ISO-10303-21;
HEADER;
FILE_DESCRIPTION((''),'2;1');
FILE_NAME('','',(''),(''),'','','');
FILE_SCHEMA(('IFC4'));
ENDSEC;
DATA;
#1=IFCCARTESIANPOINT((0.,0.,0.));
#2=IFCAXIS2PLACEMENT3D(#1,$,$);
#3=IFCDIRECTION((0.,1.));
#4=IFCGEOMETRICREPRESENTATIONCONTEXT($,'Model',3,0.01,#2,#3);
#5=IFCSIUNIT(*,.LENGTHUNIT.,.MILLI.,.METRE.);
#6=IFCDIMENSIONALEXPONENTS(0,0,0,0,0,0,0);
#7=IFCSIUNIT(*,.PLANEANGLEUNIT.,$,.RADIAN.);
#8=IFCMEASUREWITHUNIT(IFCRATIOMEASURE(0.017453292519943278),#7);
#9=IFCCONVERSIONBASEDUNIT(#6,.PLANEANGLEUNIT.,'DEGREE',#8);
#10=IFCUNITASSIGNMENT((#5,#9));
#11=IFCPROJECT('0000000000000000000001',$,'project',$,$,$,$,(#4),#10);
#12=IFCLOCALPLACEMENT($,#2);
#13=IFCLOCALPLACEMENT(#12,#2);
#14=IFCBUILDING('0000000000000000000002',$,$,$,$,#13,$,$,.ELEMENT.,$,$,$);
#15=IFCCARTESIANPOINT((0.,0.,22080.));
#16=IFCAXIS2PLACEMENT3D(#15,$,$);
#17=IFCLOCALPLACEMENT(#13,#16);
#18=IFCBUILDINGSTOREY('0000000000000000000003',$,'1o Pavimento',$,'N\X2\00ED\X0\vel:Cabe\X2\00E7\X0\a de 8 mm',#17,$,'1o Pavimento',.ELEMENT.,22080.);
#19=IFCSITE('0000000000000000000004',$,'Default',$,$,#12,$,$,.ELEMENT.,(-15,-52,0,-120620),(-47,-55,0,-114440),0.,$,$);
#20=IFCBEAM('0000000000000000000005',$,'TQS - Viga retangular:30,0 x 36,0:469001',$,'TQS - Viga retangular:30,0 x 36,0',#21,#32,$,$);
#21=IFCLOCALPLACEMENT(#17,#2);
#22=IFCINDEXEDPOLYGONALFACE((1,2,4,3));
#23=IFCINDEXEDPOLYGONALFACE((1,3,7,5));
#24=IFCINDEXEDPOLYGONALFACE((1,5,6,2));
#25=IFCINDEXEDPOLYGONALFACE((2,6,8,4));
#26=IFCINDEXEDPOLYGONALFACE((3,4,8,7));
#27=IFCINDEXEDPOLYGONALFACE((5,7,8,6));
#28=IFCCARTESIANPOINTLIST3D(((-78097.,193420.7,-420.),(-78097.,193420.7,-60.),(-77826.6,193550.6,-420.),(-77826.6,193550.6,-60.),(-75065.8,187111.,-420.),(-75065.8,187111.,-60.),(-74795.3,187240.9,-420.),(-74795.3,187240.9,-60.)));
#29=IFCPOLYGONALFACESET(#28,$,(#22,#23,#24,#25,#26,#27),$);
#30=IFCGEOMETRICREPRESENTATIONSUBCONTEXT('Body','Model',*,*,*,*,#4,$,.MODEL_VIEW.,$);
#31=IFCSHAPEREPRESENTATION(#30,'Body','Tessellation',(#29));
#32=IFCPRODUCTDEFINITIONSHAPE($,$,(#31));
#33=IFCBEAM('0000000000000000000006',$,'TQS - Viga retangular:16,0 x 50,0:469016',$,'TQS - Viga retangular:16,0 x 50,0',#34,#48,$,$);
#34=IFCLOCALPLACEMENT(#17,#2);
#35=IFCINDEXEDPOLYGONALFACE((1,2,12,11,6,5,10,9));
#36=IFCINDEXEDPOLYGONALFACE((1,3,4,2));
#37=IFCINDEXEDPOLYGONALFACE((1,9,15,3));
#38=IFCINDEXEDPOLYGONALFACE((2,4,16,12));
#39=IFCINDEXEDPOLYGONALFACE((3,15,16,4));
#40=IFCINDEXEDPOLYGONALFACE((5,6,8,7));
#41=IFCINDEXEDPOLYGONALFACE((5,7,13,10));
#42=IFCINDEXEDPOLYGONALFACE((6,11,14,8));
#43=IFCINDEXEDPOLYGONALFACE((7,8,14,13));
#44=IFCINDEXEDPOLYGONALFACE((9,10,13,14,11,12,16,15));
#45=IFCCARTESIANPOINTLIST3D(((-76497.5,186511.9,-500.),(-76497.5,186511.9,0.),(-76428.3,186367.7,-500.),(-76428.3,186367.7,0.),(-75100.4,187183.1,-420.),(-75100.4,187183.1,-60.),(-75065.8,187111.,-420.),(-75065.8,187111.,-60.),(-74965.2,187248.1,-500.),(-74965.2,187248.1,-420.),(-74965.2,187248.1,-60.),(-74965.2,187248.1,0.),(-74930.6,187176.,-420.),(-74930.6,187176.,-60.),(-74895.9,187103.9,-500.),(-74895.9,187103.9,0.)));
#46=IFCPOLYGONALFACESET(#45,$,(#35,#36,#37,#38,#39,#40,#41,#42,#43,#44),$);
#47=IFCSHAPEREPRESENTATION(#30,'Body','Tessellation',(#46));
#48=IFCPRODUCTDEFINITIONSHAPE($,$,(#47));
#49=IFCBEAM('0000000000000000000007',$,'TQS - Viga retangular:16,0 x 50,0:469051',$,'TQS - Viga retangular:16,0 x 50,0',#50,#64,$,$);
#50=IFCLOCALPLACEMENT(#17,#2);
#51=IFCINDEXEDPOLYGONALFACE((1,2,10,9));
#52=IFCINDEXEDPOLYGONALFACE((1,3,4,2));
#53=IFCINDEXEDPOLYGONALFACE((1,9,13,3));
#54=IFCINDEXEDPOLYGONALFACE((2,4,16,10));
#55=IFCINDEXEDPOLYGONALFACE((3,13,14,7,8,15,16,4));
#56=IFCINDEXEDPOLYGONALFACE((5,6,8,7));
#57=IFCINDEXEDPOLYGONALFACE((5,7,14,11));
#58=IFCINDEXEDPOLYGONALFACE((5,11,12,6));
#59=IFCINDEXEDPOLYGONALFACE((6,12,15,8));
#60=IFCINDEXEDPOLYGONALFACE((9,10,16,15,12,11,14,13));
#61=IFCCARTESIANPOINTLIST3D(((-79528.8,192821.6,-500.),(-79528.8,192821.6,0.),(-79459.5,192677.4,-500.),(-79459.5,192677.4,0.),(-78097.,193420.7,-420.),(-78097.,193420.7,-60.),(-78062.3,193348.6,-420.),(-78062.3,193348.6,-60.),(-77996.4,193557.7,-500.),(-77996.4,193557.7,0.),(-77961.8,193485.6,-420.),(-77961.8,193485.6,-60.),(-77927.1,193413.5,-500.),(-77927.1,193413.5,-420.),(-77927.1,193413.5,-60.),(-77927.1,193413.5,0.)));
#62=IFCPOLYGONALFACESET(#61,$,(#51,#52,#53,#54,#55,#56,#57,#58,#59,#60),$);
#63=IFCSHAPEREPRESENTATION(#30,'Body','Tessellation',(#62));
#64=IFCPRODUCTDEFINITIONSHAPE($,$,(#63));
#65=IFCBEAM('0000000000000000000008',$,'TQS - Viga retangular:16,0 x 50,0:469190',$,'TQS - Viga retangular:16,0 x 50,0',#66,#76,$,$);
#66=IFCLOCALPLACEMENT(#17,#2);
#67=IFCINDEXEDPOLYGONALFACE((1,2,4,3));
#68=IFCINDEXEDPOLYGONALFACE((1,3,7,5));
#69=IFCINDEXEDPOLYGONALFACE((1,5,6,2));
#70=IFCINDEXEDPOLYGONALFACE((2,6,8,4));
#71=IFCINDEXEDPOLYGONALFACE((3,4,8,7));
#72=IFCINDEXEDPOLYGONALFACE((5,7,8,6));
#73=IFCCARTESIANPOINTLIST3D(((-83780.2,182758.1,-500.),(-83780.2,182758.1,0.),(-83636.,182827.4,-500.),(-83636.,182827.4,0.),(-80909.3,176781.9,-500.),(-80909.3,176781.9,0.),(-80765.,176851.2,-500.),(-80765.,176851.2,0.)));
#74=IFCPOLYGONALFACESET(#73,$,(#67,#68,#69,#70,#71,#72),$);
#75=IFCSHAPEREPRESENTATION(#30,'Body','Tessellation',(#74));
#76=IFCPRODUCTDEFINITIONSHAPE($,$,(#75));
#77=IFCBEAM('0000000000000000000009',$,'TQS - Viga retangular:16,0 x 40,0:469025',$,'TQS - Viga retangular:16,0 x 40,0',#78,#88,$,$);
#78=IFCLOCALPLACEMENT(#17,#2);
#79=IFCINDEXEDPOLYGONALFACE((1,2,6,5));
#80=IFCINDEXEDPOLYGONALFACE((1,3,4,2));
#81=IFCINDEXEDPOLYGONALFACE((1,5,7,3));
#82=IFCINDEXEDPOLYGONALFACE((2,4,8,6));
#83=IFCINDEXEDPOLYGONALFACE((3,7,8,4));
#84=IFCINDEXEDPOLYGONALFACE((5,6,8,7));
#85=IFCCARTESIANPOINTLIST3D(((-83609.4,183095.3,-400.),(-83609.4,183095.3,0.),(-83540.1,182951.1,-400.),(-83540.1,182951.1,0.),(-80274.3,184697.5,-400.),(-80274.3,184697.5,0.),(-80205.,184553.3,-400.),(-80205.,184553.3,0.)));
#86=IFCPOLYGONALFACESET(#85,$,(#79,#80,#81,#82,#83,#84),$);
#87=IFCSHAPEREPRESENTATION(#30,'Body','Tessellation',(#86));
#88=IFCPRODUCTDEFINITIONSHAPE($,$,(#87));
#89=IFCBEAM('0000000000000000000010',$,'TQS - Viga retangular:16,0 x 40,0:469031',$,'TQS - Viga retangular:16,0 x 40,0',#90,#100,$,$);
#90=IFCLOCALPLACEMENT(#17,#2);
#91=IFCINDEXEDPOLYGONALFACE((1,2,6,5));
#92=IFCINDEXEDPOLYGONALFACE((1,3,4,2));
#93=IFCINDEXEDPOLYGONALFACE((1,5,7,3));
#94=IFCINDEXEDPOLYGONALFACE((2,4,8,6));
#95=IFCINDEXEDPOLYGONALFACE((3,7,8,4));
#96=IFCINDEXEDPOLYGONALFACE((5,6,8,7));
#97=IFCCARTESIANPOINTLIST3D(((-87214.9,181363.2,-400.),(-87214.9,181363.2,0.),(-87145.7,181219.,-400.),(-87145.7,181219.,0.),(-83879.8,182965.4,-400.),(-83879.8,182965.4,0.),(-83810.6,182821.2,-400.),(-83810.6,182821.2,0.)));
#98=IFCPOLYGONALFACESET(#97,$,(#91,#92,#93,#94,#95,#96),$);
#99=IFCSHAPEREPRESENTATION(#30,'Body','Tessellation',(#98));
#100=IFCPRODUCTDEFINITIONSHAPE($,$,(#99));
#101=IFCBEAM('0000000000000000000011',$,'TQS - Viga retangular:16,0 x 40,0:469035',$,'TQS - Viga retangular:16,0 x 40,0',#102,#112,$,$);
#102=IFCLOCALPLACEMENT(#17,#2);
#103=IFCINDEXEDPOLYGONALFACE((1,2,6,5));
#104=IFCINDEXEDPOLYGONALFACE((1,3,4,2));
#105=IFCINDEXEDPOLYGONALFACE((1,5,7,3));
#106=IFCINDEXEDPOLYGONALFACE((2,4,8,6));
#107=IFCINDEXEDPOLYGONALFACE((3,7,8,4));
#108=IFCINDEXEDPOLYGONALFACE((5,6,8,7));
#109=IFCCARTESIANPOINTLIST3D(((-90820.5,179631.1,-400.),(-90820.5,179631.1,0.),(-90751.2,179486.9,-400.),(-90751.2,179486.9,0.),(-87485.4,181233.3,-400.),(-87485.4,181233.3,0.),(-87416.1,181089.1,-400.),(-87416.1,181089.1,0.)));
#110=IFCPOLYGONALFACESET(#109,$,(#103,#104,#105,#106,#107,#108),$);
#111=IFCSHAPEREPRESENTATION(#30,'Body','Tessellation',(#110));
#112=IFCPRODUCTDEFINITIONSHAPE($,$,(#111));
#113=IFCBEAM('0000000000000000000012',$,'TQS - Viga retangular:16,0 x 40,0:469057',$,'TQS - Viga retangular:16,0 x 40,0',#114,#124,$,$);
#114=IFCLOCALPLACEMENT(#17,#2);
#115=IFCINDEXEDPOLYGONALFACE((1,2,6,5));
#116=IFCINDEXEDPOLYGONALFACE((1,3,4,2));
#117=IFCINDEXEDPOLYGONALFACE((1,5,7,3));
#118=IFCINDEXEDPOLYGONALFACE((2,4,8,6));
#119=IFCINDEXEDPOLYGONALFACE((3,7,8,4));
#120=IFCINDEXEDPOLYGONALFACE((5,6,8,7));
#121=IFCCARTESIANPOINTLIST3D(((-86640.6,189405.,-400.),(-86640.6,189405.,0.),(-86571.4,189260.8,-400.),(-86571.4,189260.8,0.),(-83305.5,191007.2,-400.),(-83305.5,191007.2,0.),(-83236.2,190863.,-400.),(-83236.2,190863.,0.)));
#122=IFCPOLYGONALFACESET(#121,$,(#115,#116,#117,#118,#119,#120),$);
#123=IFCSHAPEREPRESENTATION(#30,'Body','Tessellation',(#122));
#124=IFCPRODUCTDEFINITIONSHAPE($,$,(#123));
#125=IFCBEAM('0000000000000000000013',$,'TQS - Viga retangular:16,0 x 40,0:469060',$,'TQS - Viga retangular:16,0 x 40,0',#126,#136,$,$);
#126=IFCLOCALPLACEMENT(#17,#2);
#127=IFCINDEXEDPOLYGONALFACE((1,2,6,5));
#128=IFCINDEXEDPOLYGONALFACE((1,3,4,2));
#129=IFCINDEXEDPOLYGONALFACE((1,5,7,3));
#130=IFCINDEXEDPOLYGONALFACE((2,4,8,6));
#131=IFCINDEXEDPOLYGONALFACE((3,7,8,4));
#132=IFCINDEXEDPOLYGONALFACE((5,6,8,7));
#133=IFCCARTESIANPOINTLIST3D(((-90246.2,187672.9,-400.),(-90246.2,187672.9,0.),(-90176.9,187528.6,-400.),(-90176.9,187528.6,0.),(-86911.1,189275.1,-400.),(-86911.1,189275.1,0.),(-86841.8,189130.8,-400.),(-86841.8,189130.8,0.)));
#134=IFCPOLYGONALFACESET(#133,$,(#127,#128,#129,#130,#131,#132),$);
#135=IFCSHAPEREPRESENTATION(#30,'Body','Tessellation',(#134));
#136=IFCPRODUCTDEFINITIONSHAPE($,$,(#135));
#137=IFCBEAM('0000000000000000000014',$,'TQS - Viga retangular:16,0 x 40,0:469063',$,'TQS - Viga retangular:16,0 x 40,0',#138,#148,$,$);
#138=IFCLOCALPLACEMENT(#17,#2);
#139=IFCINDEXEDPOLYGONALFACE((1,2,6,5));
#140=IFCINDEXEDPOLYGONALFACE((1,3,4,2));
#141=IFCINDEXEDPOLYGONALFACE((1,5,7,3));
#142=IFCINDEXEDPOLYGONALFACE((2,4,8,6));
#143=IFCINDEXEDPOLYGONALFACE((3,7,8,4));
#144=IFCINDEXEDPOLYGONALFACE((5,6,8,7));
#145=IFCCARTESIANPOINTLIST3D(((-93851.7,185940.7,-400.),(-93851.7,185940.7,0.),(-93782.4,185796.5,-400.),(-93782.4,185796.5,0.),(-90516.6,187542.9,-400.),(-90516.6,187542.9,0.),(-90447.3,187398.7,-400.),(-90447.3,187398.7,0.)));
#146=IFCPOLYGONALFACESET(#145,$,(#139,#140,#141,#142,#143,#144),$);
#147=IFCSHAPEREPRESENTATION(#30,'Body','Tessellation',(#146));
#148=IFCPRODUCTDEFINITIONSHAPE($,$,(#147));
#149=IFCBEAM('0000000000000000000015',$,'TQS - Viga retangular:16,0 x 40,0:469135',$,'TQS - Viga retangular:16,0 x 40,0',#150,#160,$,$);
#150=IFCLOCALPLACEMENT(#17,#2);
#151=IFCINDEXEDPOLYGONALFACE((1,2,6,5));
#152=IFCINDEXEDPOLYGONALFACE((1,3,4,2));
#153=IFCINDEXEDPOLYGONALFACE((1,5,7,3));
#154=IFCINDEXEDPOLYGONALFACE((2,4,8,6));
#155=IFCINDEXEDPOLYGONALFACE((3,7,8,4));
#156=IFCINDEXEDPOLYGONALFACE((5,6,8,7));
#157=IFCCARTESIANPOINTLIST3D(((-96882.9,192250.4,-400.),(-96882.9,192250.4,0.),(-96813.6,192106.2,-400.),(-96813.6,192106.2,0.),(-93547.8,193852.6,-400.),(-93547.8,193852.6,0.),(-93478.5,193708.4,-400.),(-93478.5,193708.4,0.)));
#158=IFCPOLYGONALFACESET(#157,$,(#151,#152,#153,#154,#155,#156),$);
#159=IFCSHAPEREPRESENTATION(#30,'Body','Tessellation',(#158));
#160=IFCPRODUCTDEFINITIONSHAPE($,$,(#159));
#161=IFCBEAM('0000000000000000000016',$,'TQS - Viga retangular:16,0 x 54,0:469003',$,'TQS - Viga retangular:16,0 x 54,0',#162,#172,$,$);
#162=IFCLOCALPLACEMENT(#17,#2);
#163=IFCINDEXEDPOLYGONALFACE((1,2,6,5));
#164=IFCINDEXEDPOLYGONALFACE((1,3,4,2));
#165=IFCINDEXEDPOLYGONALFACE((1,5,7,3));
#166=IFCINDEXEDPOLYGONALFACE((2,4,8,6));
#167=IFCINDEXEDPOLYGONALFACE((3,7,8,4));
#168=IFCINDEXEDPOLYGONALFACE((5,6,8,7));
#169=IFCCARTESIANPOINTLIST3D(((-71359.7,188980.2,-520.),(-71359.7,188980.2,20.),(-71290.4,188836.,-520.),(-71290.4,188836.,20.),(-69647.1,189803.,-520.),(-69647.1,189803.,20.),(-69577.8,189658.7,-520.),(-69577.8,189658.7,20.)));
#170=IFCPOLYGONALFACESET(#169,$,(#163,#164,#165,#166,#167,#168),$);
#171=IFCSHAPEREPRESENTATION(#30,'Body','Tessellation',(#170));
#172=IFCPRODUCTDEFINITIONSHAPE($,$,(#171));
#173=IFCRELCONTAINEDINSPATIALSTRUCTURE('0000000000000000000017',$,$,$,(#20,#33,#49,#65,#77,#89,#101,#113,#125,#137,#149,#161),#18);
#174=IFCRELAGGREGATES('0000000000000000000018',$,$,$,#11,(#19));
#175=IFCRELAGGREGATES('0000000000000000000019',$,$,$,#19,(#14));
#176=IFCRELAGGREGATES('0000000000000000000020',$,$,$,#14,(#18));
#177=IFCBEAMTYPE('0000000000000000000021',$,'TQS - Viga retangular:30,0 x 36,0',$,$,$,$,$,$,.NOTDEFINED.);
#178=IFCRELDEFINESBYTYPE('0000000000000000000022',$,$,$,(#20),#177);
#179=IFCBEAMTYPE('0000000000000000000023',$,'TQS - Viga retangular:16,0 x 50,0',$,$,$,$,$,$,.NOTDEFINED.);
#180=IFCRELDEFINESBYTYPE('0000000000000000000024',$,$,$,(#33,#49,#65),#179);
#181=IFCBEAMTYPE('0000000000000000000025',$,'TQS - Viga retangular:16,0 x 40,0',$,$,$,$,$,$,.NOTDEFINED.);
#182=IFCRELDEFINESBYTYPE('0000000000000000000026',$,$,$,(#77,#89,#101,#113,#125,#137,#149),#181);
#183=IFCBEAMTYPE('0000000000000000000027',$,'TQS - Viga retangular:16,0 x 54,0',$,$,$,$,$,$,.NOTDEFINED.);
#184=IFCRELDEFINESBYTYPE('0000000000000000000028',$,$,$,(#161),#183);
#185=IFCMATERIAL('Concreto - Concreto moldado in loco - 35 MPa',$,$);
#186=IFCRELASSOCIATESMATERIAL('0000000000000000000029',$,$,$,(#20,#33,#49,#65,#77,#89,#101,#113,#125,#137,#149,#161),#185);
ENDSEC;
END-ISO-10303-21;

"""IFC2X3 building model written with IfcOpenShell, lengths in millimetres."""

from ifc_helpers import new_model, entity, si_unit, converted_unit, direction, frame, frame_2d, origin, origin_2d_with_axis, place, context, subcontext, project, spatial, polyline, rectangle, extrude, boolean, clip, bounded_halfspace, material, type_object, element, save


model = new_model("IFC2X3")

# Units and contexts
model_context = context("Model", 3, precision=0.01, world=origin(), true_north=direction((0.0, 1.0)))
body_context = subcontext(model_context, "Body", "Model", "MODEL_VIEW")
ifc_project = project(units=[si_unit("LENGTHUNIT", "METRE", prefix="MILLI"), converted_unit("PLANEANGLEUNIT", "DEGREE", entity("IfcRatioMeasure", 0.017453292519943278), si_unit("PLANEANGLEUNIT", "RADIAN"), dimensions=[0, 0, 0, 0, 0, 0, 0])], contexts=[model_context])

# Site, building, storey
site_placement = place(None, origin())
site = spatial("IfcSite", under=ifc_project, at=site_placement, Name="Default", CompositionType="ELEMENT", RefLatitude=(-15, -52, 0, -120620), RefLongitude=(-47, -55, 0, -114440), RefElevation=0.0)
building_placement = place(site_placement, origin())
building = spatial("IfcBuilding", under=site, at=building_placement, CompositionType="ELEMENT")
storey_placement = place(building_placement, frame((0.0, 0.0, 22080.0)))
storey = spatial("IfcBuildingStorey", under=building, at=storey_placement, Name="1o Pavimento", ObjectType="Nível:Cabeça de 8 mm", LongName="1o Pavimento", CompositionType="ELEMENT", Elevation=22080.0)

# Beams
ifc_material_1 = material(Name="Concreto - Concreto moldado in loco - 35 MPa")
beam_type_1 = type_object("IfcBeamType", Name="TQS - Viga retangular:30,0 x 36,0", PredefinedType="NOTDEFINED")
beam_1_placement = place(storey_placement, frame((-74930.6, 187176.0, -60.0), z_axis=(0.0, 0.0, 1.0), x_axis=(-0.43303, 0.90138, 0.0)))
element("IfcBeam", 1, at=beam_1_placement, inside=storey, type_object=beam_type_1, material=ifc_material_1, Name="TQS - Viga retangular:30,0 x 36,0:469001", ObjectType="TQS - Viga retangular:30,0 x 36,0", context=body_context, shape_type="SweptSolid", body=[
    extrude(rectangle(XDim=360.0, YDim=300.0, at=frame_2d((0.0, 0.0), x_axis=(1.0, 0.0))), frame((0.0, 0.0, -180.0), z_axis=(1.0, 0.0, 0.0), x_axis=(0.0, 0.0, -1.0)), (0.0, 0.0, 1.0), 7000.0),
])
beam_type_2 = type_object("IfcBeamType", Name="TQS - Viga retangular:16,0 x 50,0", PredefinedType="NOTDEFINED")
beam_2_placement = place(storey_placement, frame((-74930.6, 187176.0, 0.0), z_axis=(0.0, 0.0, 1.0), x_axis=(-0.90138, -0.43303, 0.0)))
element("IfcBeam", 2, at=beam_2_placement, inside=storey, type_object=beam_type_2, material=ifc_material_1, Name="TQS - Viga retangular:16,0 x 50,0:469016", ObjectType="TQS - Viga retangular:16,0 x 50,0", context=body_context, shape_type="SweptSolid", body=[
    boolean("DIFFERENCE", clip(extrude(rectangle(XDim=500.0, YDim=160.0, at=frame_2d((0.0, 0.0), x_axis=(0.0, 1.0))), frame((0.0, 0.0, -250.0), z_axis=(1.0, 0.0, 0.0), x_axis=(0.0, 1.0, 0.0)), (0.0, 0.0, 1.0), 1700.0), bounded_halfspace(frame((150.0, -7000.0, -420.0), z_axis=(-1.0, 0.0, 0.0), x_axis=(0.0, 1.0, 0.0)), False, frame((0.0, 0.0, -250.0), z_axis=(1.0, 0.0, 0.0), x_axis=(0.0, 1.0, 0.0)), polyline([(0.0, 190.0), (0.0, -170.0), (-80.0, -170.0), (-80.0, 90.0), (-80.0, 190.0), (0.0, 190.0)]))), extrude(rectangle(XDim=360.0, YDim=80.0, at=frame_2d((0.0, 0.0), x_axis=(0.0, 1.0))), frame((150.0, -40.0, -240.0), z_axis=(1.0, 0.0, 0.0), x_axis=(0.0, 1.0, 0.0)), (0.0, 0.0, -1.0), 150.0)),
])
beam_3_placement = place(storey_placement, frame((-77961.8, 193485.6, 0.0), z_axis=(0.0, 0.0, 1.0), x_axis=(-0.90138, -0.43303, 0.0)))
element("IfcBeam", 3, at=beam_3_placement, inside=storey, type_object=beam_type_2, material=ifc_material_1, Name="TQS - Viga retangular:16,0 x 50,0:469051", ObjectType="TQS - Viga retangular:16,0 x 50,0", context=body_context, shape_type="SweptSolid", body=[
    boolean("DIFFERENCE", clip(extrude(rectangle(XDim=500.0, YDim=160.0, at=frame_2d((0.0, 0.0), x_axis=(1.0, 0.0))), frame((0.0, 0.0, -250.0), z_axis=(1.0, 0.0, 0.0), x_axis=(0.0, 0.0, -1.0)), (0.0, 0.0, 1.0), 1700.0), bounded_halfspace(frame((150.0, 0.0, -420.0), z_axis=(-1.0, 0.0, 0.0), x_axis=(0.0, 1.0, 0.0)), False, frame((0.0, 0.0, -250.0), z_axis=(1.0, 0.0, 0.0), x_axis=(0.0, 0.0, -1.0)), polyline([(170.0, 0.0), (-190.0, 0.0), (-190.0, 80.0), (-90.0, 80.0), (170.0, 80.0), (170.0, 0.0)]))), extrude(rectangle(XDim=360.0, YDim=80.0, at=frame_2d((0.0, 0.0), x_axis=(0.0, 1.0))), frame((0.0, 40.0, -240.0), z_axis=(-1.0, 0.0, 0.0), x_axis=(0.0, -1.0, 0.0)), (0.0, 0.0, -1.0), 150.0)),
])
beam_4_placement = place(storey_placement, frame((-80837.1, 176816.6, 0.0), z_axis=(0.0, 0.0, 1.0), x_axis=(-0.43303, 0.90138, 0.0)))
element("IfcBeam", 4, at=beam_4_placement, inside=storey, type_object=beam_type_2, material=ifc_material_1, Name="TQS - Viga retangular:16,0 x 50,0:469190", ObjectType="TQS - Viga retangular:16,0 x 50,0", context=body_context, shape_type="SweptSolid", body=[
    extrude(rectangle(XDim=500.0, YDim=160.0, at=frame_2d((0.0, 0.0), x_axis=(1.0, 0.0))), frame((0.0, 0.0, -250.0), z_axis=(1.0, 0.0, 0.0), x_axis=(0.0, 0.0, -1.0)), (0.0, 0.0, 1.0), 6630.0),
])
beam_type_3 = type_object("IfcBeamType", Name="TQS - Viga retangular:16,0 x 40,0", PredefinedType="NOTDEFINED")
beam_5_placement = place(storey_placement, frame((-80167.6, 184660.1, 0.0), z_axis=(0.0, 0.0, 1.0), x_axis=(-0.90138, -0.43303, 0.0)))
element("IfcBeam", 5, at=beam_5_placement, inside=storey, type_object=beam_type_3, material=ifc_material_1, Name="TQS - Viga retangular:16,0 x 40,0:469025", ObjectType="TQS - Viga retangular:16,0 x 40,0", context=body_context, shape_type="SweptSolid", body=[
    extrude(rectangle(XDim=400.0, YDim=160.0, at=frame_2d((0.0, 0.0), x_axis=(1.0, 0.0))), frame((80.0, 0.0, -200.0), z_axis=(1.0, 0.0, 0.0), x_axis=(0.0, 0.0, -1.0)), (0.0, 0.0, 1.0), 3700.0),
])
beam_6_placement = place(storey_placement, frame((-83773.1, 182927.9, 0.0), z_axis=(0.0, 0.0, 1.0), x_axis=(-0.90138, -0.43303, 0.0)))
element("IfcBeam", 6, at=beam_6_placement, inside=storey, type_object=beam_type_3, material=ifc_material_1, Name="TQS - Viga retangular:16,0 x 40,0:469031", ObjectType="TQS - Viga retangular:16,0 x 40,0", context=body_context, shape_type="SweptSolid", body=[
    extrude(rectangle(XDim=400.0, YDim=160.0, at=frame_2d((0.0, 0.0), x_axis=(1.0, 0.0))), frame((80.0, 0.0, -200.0), z_axis=(1.0, 0.0, 0.0), x_axis=(0.0, 0.0, -1.0)), (0.0, 0.0, 1.0), 3700.0),
])
beam_7_placement = place(storey_placement, frame((-87378.6, 181195.8, 0.0), z_axis=(0.0, 0.0, 1.0), x_axis=(-0.90138, -0.43303, 0.0)))
element("IfcBeam", 7, at=beam_7_placement, inside=storey, type_object=beam_type_3, material=ifc_material_1, Name="TQS - Viga retangular:16,0 x 40,0:469035", ObjectType="TQS - Viga retangular:16,0 x 40,0", context=body_context, shape_type="SweptSolid", body=[
    extrude(rectangle(XDim=400.0, YDim=160.0, at=frame_2d((0.0, 0.0), x_axis=(1.0, 0.0))), frame((80.0, 0.0, -200.0), z_axis=(1.0, 0.0, 0.0), x_axis=(0.0, 0.0, -1.0)), (0.0, 0.0, 1.0), 3700.0),
])
beam_8_placement = place(storey_placement, frame((-83198.8, 190969.7, 0.0), z_axis=(0.0, 0.0, 1.0), x_axis=(-0.90138, -0.43303, 0.0)))
element("IfcBeam", 8, at=beam_8_placement, inside=storey, type_object=beam_type_3, material=ifc_material_1, Name="TQS - Viga retangular:16,0 x 40,0:469057", ObjectType="TQS - Viga retangular:16,0 x 40,0", context=body_context, shape_type="SweptSolid", body=[
    extrude(rectangle(XDim=400.0, YDim=160.0, at=frame_2d((0.0, 0.0), x_axis=(1.0, 0.0))), frame((80.0, 0.0, -200.0), z_axis=(1.0, 0.0, 0.0), x_axis=(0.0, 0.0, -1.0)), (0.0, 0.0, 1.0), 3700.0),
])
beam_9_placement = place(storey_placement, frame((-86804.3, 189237.6, 0.0), z_axis=(0.0, 0.0, 1.0), x_axis=(-0.90138, -0.43303, 0.0)))
element("IfcBeam", 9, at=beam_9_placement, inside=storey, type_object=beam_type_3, material=ifc_material_1, Name="TQS - Viga retangular:16,0 x 40,0:469060", ObjectType="TQS - Viga retangular:16,0 x 40,0", context=body_context, shape_type="SweptSolid", body=[
    extrude(rectangle(XDim=400.0, YDim=160.0, at=frame_2d((0.0, 0.0), x_axis=(1.0, 0.0))), frame((80.0, 0.0, -200.0), z_axis=(1.0, 0.0, 0.0), x_axis=(0.0, 0.0, -1.0)), (0.0, 0.0, 1.0), 3700.0),
])
beam_10_placement = place(storey_placement, frame((-90409.8, 187505.5, 0.0), z_axis=(0.0, 0.0, 1.0), x_axis=(-0.90138, -0.43303, 0.0)))
element("IfcBeam", 10, at=beam_10_placement, inside=storey, type_object=beam_type_3, material=ifc_material_1, Name="TQS - Viga retangular:16,0 x 40,0:469063", ObjectType="TQS - Viga retangular:16,0 x 40,0", context=body_context, shape_type="SweptSolid", body=[
    extrude(rectangle(XDim=400.0, YDim=160.0, at=frame_2d((0.0, 0.0), x_axis=(1.0, 0.0))), frame((80.0, 0.0, -200.0), z_axis=(1.0, 0.0, 0.0), x_axis=(0.0, 0.0, -1.0)), (0.0, 0.0, 1.0), 3700.0),
])
beam_11_placement = place(storey_placement, frame((-93441.0, 193815.1, 0.0), z_axis=(0.0, 0.0, 1.0), x_axis=(-0.90138, -0.43303, 0.0)))
element("IfcBeam", 11, at=beam_11_placement, inside=storey, type_object=beam_type_3, material=ifc_material_1, Name="TQS - Viga retangular:16,0 x 40,0:469135", ObjectType="TQS - Viga retangular:16,0 x 40,0", context=body_context, shape_type="SweptSolid", body=[
    extrude(rectangle(XDim=400.0, YDim=160.0, at=frame_2d((0.0, 0.0), x_axis=(1.0, 0.0))), frame((80.0, 0.0, -200.0), z_axis=(1.0, 0.0, 0.0), x_axis=(0.0, 0.0, -1.0)), (0.0, 0.0, 1.0), 3700.0),
])
beam_type_4 = type_object("IfcBeamType", Name="TQS - Viga retangular:16,0 x 54,0", PredefinedType="NOTDEFINED")
beam_12_placement = place(storey_placement, frame((-69612.4, 189730.8, 20.0), z_axis=(0.0, 0.0, 1.0), x_axis=(-0.90138, -0.43303, 0.0)))
element("IfcBeam", 12, at=beam_12_placement, inside=storey, type_object=beam_type_4, material=ifc_material_1, Name="TQS - Viga retangular:16,0 x 54,0:469003", ObjectType="TQS - Viga retangular:16,0 x 54,0", context=body_context, shape_type="SweptSolid", body=[
    extrude(rectangle(XDim=540.0, YDim=160.0, at=origin_2d_with_axis()), frame((0.0, 0.0, -270.0), z_axis=(1.0, 0.0, 0.0), x_axis=(0.0, 0.0, -1.0)), (0.0, 0.0, 1.0), 1900.0),
])

save(model, "model.ifc")
